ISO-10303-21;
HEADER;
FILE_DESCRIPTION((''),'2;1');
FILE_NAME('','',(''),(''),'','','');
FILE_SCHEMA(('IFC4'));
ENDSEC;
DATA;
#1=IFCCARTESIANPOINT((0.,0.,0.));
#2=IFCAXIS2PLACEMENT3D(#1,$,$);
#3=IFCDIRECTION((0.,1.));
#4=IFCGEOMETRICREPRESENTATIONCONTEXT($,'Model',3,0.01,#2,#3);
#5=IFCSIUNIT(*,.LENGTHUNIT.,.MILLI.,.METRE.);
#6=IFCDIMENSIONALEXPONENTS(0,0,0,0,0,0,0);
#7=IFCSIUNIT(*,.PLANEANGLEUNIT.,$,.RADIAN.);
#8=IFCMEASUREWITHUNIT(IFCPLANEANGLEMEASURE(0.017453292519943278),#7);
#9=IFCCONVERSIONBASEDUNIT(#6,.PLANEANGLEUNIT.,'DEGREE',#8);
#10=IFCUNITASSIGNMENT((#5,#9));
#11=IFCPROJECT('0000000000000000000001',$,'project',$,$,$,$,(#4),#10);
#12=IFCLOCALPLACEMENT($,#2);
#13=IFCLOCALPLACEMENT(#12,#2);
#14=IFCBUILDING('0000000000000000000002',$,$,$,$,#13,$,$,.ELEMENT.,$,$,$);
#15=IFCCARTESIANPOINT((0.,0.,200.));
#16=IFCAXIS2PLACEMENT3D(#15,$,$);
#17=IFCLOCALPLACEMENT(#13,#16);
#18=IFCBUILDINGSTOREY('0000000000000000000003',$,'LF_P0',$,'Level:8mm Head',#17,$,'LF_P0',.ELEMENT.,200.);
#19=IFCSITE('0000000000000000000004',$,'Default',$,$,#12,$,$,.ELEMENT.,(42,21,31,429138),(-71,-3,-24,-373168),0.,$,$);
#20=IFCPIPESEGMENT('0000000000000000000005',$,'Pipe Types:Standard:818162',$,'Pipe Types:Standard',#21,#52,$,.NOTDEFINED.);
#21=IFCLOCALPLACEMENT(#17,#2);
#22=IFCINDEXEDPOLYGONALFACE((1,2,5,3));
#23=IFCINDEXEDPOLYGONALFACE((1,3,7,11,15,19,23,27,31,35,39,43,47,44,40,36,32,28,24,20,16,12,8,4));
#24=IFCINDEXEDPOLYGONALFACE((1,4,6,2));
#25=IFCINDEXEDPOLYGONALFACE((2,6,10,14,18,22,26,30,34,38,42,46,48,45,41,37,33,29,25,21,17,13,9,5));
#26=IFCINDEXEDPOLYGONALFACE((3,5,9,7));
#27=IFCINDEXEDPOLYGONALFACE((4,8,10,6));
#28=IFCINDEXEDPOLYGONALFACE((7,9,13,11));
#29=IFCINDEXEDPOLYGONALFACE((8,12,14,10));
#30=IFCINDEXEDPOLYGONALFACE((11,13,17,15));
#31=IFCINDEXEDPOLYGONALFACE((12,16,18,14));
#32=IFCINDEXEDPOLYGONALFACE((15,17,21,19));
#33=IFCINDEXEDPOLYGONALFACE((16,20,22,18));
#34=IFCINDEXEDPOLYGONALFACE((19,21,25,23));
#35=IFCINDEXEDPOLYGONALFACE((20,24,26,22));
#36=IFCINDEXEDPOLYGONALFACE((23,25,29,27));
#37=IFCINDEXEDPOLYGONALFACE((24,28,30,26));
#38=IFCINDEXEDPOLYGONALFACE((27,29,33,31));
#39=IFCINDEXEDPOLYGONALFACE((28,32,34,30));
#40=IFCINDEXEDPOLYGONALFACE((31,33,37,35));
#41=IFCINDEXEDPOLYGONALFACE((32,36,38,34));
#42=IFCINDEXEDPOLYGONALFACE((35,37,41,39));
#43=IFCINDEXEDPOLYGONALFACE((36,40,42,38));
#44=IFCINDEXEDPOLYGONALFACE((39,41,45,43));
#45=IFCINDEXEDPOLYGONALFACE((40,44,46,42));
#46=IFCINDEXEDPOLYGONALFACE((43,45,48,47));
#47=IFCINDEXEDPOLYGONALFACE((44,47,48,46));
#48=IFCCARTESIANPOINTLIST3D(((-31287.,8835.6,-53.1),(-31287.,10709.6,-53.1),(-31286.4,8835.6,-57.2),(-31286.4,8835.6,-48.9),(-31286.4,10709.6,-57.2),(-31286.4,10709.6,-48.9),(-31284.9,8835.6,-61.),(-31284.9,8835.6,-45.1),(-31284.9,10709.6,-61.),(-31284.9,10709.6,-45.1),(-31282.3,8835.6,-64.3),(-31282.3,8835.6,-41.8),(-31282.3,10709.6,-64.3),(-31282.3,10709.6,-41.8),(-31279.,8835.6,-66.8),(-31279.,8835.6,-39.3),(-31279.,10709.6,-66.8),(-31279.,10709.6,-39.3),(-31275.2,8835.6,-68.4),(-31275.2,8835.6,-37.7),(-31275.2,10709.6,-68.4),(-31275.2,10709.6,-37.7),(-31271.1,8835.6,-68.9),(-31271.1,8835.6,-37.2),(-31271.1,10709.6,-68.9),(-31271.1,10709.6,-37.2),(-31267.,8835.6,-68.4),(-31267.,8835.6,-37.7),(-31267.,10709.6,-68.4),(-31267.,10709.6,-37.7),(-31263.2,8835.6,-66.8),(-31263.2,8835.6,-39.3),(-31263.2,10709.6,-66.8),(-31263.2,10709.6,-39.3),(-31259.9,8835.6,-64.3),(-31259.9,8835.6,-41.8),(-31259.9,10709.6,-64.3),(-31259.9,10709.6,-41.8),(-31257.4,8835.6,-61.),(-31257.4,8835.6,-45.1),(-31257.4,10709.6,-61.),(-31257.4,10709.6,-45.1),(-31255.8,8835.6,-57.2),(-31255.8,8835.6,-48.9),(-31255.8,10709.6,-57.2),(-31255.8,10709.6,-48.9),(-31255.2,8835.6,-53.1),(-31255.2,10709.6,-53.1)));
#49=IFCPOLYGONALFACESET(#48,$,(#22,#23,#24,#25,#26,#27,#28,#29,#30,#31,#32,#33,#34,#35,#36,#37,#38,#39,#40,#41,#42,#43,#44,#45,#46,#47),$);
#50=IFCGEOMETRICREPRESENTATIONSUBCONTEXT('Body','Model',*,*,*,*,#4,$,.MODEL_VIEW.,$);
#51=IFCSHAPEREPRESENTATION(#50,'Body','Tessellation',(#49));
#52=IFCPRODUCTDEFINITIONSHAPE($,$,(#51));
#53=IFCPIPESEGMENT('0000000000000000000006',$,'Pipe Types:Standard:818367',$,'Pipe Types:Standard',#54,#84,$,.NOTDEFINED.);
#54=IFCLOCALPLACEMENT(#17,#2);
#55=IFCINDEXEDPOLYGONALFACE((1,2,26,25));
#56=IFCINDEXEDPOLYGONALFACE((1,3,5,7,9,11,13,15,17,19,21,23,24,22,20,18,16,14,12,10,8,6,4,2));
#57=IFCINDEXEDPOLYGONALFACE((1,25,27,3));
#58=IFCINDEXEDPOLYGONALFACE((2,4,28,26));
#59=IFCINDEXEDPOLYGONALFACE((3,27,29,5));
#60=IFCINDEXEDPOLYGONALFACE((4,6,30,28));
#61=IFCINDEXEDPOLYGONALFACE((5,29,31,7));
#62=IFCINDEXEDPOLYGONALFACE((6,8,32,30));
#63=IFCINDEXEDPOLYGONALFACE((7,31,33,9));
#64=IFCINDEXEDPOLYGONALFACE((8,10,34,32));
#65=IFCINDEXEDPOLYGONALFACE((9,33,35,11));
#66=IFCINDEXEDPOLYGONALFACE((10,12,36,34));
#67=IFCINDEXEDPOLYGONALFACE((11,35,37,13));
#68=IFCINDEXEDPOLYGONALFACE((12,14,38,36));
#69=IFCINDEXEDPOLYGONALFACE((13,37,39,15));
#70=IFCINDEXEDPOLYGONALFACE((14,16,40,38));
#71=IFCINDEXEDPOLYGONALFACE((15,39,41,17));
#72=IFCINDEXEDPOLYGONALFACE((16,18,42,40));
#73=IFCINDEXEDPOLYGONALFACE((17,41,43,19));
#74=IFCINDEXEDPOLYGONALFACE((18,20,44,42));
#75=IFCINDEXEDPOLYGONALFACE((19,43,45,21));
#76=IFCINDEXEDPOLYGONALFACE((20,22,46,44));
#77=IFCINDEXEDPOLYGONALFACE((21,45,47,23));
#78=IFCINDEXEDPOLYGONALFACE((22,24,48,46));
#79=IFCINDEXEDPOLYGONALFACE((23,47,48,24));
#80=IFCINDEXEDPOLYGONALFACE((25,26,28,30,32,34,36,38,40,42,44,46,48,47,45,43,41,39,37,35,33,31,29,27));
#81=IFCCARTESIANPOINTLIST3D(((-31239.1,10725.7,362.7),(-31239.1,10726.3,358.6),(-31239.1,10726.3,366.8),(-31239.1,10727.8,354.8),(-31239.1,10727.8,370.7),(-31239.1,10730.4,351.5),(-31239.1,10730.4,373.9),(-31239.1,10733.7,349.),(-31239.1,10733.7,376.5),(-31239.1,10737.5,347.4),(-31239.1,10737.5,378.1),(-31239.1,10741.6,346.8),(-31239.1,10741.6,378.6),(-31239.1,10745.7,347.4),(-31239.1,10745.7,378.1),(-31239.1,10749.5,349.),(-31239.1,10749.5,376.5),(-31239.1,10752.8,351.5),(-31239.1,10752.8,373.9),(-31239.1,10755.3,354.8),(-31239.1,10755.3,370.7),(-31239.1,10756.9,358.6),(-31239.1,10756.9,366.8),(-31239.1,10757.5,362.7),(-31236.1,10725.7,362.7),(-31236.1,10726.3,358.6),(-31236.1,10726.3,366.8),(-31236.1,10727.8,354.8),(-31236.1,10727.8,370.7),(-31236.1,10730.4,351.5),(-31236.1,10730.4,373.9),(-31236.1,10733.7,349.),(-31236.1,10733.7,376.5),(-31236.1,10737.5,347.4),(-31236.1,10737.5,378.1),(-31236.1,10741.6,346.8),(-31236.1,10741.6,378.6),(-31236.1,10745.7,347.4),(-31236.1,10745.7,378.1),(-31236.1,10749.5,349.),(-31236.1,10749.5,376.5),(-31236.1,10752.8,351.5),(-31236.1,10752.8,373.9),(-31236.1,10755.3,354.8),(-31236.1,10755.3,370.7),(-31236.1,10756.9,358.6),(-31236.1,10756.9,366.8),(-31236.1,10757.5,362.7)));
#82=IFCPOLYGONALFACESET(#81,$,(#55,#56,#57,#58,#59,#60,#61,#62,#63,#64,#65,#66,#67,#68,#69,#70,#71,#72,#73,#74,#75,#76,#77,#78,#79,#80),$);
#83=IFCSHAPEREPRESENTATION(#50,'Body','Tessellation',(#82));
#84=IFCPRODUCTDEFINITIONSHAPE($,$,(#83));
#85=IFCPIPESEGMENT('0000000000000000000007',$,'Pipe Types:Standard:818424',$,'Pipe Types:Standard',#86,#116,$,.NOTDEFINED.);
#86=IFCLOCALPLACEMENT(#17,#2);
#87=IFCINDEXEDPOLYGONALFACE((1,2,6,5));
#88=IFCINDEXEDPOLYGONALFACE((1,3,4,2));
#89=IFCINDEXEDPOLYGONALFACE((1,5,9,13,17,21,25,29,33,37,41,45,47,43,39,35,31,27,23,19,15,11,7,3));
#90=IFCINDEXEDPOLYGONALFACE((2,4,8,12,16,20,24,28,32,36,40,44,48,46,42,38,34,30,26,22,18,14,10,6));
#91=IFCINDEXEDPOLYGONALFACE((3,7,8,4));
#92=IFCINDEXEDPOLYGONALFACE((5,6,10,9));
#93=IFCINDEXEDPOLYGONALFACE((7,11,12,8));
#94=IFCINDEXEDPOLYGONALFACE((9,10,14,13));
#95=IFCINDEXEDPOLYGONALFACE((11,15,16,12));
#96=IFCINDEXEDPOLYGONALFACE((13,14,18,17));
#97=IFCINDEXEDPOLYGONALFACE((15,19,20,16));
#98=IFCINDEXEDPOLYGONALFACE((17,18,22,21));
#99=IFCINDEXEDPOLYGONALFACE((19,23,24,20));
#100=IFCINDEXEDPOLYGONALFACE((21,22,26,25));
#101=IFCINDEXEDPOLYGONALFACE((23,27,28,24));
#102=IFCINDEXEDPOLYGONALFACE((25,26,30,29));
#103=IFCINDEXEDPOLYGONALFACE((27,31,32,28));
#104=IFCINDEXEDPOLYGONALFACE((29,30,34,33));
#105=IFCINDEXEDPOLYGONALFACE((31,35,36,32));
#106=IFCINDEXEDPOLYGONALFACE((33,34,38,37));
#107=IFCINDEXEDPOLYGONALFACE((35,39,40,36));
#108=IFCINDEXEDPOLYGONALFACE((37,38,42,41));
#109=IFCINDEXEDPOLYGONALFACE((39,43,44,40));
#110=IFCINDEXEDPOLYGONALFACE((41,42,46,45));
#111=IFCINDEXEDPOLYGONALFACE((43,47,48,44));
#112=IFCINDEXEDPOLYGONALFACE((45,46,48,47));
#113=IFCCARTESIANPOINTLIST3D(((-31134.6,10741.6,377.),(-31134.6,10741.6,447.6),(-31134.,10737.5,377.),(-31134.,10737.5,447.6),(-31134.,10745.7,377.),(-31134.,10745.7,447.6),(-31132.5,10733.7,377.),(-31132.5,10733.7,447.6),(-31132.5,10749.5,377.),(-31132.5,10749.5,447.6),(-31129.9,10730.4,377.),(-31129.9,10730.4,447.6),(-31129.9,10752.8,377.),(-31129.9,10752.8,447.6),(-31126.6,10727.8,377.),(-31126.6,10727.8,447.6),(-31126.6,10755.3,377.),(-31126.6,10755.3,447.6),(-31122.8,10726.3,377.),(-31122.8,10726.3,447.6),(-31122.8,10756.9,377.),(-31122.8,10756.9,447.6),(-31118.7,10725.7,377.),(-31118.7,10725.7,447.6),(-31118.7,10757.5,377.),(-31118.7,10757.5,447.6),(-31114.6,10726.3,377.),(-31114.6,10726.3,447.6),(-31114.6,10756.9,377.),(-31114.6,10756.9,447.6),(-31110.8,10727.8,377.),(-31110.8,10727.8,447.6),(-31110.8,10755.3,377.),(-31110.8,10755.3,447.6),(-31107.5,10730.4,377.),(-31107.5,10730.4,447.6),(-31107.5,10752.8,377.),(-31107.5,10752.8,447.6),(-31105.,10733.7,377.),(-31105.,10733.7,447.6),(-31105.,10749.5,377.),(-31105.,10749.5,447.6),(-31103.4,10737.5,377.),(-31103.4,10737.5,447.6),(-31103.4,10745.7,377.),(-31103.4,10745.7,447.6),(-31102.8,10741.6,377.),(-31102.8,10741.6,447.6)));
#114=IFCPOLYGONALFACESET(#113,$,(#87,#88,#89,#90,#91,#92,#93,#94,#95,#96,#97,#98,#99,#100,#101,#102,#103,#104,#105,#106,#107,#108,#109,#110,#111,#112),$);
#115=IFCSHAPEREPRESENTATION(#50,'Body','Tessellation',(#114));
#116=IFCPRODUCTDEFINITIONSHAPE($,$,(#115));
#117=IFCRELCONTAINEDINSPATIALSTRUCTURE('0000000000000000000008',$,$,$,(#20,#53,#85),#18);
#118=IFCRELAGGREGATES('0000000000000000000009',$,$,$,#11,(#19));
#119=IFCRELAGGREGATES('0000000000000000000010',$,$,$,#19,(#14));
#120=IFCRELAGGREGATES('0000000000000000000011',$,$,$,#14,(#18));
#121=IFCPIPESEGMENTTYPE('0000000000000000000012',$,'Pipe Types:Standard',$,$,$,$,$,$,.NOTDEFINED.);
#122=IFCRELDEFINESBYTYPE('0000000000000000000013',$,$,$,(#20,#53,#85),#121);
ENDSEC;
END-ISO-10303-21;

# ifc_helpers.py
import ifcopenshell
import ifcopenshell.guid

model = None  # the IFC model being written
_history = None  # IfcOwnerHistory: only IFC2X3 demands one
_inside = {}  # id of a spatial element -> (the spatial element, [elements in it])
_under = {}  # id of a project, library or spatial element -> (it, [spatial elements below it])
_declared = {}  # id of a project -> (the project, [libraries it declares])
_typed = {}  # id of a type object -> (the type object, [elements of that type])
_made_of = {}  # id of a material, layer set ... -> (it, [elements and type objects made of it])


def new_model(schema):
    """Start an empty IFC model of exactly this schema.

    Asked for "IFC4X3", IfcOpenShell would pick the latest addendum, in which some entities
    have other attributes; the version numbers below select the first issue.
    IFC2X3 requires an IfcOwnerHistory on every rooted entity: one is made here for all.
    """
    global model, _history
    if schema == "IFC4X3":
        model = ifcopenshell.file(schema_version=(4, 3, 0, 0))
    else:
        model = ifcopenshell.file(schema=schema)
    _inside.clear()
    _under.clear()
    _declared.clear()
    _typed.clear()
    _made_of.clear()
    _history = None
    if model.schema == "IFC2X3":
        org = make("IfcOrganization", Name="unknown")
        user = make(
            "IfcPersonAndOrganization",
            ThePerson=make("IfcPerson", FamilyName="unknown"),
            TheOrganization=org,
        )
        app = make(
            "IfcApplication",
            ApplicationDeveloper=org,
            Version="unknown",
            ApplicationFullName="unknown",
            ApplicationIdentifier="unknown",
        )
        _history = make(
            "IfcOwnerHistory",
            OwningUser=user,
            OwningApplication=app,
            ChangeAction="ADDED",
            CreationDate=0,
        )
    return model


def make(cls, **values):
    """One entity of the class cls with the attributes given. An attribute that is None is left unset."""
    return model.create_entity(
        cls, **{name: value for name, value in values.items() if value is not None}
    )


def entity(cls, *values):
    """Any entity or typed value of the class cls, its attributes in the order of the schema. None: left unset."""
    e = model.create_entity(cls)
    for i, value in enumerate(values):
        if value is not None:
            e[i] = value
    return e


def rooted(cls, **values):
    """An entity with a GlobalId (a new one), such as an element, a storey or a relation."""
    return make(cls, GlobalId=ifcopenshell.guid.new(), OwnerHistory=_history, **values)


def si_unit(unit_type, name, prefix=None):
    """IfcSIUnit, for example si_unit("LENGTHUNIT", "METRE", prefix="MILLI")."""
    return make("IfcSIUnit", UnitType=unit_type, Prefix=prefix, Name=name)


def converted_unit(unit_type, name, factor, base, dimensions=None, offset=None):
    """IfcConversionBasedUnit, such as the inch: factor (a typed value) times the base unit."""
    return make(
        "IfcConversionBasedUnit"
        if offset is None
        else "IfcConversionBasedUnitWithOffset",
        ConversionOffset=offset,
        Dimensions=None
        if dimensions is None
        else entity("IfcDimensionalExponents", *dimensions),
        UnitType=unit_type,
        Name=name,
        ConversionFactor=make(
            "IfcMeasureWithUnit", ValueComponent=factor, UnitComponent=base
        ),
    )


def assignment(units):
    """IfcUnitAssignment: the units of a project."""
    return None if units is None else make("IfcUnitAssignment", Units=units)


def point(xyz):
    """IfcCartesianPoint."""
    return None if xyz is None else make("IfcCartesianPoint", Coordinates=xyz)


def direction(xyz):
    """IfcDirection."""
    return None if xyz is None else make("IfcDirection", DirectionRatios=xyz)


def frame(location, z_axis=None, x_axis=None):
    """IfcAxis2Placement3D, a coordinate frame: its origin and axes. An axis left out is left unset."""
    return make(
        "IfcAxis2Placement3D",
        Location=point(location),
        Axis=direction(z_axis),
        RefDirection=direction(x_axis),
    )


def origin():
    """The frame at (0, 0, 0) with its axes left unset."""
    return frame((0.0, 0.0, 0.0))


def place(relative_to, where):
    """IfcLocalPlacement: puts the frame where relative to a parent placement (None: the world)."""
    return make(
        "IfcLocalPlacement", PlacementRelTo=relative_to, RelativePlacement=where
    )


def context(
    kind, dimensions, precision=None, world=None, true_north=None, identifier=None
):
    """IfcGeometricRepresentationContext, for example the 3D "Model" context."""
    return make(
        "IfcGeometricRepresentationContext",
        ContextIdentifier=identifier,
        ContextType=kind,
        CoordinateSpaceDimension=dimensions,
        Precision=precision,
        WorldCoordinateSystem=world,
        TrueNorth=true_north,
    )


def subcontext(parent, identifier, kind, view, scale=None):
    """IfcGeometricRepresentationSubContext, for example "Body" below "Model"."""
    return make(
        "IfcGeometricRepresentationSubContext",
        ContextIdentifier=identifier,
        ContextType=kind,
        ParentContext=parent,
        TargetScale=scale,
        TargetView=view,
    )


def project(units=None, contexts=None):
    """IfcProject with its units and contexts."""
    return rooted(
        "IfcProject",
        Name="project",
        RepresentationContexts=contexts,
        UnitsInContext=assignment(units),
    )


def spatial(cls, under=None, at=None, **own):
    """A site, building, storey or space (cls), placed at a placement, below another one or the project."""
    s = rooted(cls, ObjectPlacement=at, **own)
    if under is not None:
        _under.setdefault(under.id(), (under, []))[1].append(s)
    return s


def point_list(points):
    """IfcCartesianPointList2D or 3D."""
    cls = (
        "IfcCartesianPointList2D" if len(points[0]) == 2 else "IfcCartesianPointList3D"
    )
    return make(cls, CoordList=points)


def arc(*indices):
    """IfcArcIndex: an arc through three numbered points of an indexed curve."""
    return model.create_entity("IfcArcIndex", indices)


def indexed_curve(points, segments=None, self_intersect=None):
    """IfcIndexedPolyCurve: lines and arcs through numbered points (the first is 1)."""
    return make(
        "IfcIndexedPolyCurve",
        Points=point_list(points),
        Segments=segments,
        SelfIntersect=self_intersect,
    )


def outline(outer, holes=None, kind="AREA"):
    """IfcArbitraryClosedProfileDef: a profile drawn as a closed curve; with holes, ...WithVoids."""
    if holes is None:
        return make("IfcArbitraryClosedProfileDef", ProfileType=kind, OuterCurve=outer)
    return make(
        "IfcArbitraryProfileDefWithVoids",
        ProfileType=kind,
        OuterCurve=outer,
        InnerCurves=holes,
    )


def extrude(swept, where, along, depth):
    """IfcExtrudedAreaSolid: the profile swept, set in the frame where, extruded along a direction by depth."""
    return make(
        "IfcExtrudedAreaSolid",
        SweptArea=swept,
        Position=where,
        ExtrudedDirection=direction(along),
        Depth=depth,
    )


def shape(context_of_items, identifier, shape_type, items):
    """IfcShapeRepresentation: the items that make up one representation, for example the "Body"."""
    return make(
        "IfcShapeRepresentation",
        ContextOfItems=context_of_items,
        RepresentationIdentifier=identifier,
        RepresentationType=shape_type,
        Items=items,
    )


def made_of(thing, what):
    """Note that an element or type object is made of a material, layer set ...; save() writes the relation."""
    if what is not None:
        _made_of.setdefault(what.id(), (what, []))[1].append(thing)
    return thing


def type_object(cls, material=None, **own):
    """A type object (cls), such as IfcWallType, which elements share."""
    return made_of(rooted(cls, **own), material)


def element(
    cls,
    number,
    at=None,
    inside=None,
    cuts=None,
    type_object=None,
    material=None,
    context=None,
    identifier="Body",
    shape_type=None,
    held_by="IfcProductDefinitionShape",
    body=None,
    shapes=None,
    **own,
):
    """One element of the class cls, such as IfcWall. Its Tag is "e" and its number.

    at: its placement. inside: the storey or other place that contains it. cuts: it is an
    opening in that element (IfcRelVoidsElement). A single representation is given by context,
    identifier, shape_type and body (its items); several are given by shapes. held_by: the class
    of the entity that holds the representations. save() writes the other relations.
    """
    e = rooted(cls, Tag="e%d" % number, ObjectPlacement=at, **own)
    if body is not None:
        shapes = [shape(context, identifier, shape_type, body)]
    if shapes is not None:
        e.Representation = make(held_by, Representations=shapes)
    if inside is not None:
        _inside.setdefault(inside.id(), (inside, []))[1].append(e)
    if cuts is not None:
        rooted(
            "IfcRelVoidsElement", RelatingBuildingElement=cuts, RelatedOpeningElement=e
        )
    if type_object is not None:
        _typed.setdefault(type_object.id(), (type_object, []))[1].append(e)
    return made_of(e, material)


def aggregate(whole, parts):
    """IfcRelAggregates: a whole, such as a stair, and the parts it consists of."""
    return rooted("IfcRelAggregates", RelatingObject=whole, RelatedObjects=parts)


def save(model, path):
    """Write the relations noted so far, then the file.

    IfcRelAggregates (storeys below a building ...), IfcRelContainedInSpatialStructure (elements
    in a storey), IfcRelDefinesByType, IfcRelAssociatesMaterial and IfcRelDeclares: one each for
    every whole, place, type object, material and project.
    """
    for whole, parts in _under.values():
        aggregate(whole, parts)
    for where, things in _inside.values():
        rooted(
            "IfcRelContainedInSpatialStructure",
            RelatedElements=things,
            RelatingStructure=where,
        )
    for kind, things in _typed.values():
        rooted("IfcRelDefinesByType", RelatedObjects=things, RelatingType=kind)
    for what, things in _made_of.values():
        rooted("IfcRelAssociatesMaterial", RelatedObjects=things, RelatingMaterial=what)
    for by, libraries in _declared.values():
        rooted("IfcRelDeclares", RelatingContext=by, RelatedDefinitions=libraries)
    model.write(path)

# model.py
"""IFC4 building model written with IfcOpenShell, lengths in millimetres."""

from ifc_helpers import new_model, entity, si_unit, converted_unit, direction, frame, origin, place, context, subcontext, project, spatial, arc, indexed_curve, outline, extrude, type_object, element, save


model = new_model("IFC4")

# Units and contexts
model_context = context("Model", 3, precision=0.01, world=origin(), true_north=direction((0.0, 1.0)))
body_context = subcontext(model_context, "Body", "Model", "MODEL_VIEW")
ifc_project = project(units=[si_unit("LENGTHUNIT", "METRE", prefix="MILLI"), converted_unit("PLANEANGLEUNIT", "DEGREE", entity("IfcPlaneAngleMeasure", 0.017453292519943278), si_unit("PLANEANGLEUNIT", "RADIAN"), dimensions=[0, 0, 0, 0, 0, 0, 0])], contexts=[model_context])

# Site, building, storey
site_placement = place(None, origin())
site = spatial("IfcSite", under=ifc_project, at=site_placement, Name="Default", CompositionType="ELEMENT", RefLatitude=(42, 21, 31, 429138), RefLongitude=(-71, -3, -24, -373168), RefElevation=0.0)
building_placement = place(site_placement, origin())
building = spatial("IfcBuilding", under=site, at=building_placement, CompositionType="ELEMENT")
storey_placement = place(building_placement, frame((0.0, 0.0, 200.0)))
storey = spatial("IfcBuildingStorey", under=building, at=storey_placement, Name="LF_P0", ObjectType="Level:8mm Head", LongName="LF_P0", CompositionType="ELEMENT", Elevation=200.0)

# Pipe segments
pipe_segment_type_1 = type_object("IfcPipeSegmentType", Name="Pipe Types:Standard", PredefinedType="NOTDEFINED")
pipe_segment_1_placement = place(storey_placement, origin())
element("IfcPipeSegment", 1, at=pipe_segment_1_placement, inside=storey, type_object=pipe_segment_type_1, Name="Pipe Types:Standard:818162", ObjectType="Pipe Types:Standard", PredefinedType="NOTDEFINED", context=body_context, shape_type="SweptSolid", body=[
    extrude(outline(indexed_curve([(15.9, 0.0), (11.2, 11.2), (0.0, 15.9), (-11.2, 11.2), (-15.9, 0.0), (-11.2, -11.2), (0.0, -15.9), (11.2, -11.2)], segments=[arc(1, 2, 3), arc(3, 4, 5), arc(5, 6, 7), arc(7, 8, 1)], self_intersect=False)), frame((-31271.1, 8835.6, -53.1), z_axis=(0.0, 1.0, 0.0), x_axis=(-1.0, 0.0, 0.0)), (0.0, 0.0, 1.0), 1873.9),
])
pipe_segment_2_placement = place(storey_placement, origin())
element("IfcPipeSegment", 2, at=pipe_segment_2_placement, inside=storey, type_object=pipe_segment_type_1, Name="Pipe Types:Standard:818367", ObjectType="Pipe Types:Standard", PredefinedType="NOTDEFINED", context=body_context, shape_type="SweptSolid", body=[
    extrude(outline(indexed_curve([(15.9, 0.0), (11.2, 11.2), (0.0, 15.9), (-11.2, 11.2), (-15.9, 0.0), (-11.2, -11.2), (0.0, -15.9), (11.2, -11.2)], segments=[arc(1, 2, 3), arc(3, 4, 5), arc(5, 6, 7), arc(7, 8, 1)], self_intersect=False)), frame((-31239.1, 10741.6, 362.7), z_axis=(1.0, 0.0, 0.0), x_axis=(0.0, -1.0, 0.0)), (0.0, 0.0, 1.0), 3.0),
])
pipe_segment_3_placement = place(storey_placement, origin())
element("IfcPipeSegment", 3, at=pipe_segment_3_placement, inside=storey, type_object=pipe_segment_type_1, Name="Pipe Types:Standard:818424", ObjectType="Pipe Types:Standard", PredefinedType="NOTDEFINED", context=body_context, shape_type="SweptSolid", body=[
    extrude(outline(indexed_curve([(15.9, 0.0), (11.2, 11.2), (0.0, 15.9), (-11.2, 11.2), (-15.9, 0.0), (-11.2, -11.2), (0.0, -15.9), (11.2, -11.2)], segments=[arc(1, 2, 3), arc(3, 4, 5), arc(5, 6, 7), arc(7, 8, 1)], self_intersect=False)), frame((-31118.7, 10741.6, 377.0)), (0.0, 0.0, 1.0), 70.6),
])

save(model, "model.ifc")
